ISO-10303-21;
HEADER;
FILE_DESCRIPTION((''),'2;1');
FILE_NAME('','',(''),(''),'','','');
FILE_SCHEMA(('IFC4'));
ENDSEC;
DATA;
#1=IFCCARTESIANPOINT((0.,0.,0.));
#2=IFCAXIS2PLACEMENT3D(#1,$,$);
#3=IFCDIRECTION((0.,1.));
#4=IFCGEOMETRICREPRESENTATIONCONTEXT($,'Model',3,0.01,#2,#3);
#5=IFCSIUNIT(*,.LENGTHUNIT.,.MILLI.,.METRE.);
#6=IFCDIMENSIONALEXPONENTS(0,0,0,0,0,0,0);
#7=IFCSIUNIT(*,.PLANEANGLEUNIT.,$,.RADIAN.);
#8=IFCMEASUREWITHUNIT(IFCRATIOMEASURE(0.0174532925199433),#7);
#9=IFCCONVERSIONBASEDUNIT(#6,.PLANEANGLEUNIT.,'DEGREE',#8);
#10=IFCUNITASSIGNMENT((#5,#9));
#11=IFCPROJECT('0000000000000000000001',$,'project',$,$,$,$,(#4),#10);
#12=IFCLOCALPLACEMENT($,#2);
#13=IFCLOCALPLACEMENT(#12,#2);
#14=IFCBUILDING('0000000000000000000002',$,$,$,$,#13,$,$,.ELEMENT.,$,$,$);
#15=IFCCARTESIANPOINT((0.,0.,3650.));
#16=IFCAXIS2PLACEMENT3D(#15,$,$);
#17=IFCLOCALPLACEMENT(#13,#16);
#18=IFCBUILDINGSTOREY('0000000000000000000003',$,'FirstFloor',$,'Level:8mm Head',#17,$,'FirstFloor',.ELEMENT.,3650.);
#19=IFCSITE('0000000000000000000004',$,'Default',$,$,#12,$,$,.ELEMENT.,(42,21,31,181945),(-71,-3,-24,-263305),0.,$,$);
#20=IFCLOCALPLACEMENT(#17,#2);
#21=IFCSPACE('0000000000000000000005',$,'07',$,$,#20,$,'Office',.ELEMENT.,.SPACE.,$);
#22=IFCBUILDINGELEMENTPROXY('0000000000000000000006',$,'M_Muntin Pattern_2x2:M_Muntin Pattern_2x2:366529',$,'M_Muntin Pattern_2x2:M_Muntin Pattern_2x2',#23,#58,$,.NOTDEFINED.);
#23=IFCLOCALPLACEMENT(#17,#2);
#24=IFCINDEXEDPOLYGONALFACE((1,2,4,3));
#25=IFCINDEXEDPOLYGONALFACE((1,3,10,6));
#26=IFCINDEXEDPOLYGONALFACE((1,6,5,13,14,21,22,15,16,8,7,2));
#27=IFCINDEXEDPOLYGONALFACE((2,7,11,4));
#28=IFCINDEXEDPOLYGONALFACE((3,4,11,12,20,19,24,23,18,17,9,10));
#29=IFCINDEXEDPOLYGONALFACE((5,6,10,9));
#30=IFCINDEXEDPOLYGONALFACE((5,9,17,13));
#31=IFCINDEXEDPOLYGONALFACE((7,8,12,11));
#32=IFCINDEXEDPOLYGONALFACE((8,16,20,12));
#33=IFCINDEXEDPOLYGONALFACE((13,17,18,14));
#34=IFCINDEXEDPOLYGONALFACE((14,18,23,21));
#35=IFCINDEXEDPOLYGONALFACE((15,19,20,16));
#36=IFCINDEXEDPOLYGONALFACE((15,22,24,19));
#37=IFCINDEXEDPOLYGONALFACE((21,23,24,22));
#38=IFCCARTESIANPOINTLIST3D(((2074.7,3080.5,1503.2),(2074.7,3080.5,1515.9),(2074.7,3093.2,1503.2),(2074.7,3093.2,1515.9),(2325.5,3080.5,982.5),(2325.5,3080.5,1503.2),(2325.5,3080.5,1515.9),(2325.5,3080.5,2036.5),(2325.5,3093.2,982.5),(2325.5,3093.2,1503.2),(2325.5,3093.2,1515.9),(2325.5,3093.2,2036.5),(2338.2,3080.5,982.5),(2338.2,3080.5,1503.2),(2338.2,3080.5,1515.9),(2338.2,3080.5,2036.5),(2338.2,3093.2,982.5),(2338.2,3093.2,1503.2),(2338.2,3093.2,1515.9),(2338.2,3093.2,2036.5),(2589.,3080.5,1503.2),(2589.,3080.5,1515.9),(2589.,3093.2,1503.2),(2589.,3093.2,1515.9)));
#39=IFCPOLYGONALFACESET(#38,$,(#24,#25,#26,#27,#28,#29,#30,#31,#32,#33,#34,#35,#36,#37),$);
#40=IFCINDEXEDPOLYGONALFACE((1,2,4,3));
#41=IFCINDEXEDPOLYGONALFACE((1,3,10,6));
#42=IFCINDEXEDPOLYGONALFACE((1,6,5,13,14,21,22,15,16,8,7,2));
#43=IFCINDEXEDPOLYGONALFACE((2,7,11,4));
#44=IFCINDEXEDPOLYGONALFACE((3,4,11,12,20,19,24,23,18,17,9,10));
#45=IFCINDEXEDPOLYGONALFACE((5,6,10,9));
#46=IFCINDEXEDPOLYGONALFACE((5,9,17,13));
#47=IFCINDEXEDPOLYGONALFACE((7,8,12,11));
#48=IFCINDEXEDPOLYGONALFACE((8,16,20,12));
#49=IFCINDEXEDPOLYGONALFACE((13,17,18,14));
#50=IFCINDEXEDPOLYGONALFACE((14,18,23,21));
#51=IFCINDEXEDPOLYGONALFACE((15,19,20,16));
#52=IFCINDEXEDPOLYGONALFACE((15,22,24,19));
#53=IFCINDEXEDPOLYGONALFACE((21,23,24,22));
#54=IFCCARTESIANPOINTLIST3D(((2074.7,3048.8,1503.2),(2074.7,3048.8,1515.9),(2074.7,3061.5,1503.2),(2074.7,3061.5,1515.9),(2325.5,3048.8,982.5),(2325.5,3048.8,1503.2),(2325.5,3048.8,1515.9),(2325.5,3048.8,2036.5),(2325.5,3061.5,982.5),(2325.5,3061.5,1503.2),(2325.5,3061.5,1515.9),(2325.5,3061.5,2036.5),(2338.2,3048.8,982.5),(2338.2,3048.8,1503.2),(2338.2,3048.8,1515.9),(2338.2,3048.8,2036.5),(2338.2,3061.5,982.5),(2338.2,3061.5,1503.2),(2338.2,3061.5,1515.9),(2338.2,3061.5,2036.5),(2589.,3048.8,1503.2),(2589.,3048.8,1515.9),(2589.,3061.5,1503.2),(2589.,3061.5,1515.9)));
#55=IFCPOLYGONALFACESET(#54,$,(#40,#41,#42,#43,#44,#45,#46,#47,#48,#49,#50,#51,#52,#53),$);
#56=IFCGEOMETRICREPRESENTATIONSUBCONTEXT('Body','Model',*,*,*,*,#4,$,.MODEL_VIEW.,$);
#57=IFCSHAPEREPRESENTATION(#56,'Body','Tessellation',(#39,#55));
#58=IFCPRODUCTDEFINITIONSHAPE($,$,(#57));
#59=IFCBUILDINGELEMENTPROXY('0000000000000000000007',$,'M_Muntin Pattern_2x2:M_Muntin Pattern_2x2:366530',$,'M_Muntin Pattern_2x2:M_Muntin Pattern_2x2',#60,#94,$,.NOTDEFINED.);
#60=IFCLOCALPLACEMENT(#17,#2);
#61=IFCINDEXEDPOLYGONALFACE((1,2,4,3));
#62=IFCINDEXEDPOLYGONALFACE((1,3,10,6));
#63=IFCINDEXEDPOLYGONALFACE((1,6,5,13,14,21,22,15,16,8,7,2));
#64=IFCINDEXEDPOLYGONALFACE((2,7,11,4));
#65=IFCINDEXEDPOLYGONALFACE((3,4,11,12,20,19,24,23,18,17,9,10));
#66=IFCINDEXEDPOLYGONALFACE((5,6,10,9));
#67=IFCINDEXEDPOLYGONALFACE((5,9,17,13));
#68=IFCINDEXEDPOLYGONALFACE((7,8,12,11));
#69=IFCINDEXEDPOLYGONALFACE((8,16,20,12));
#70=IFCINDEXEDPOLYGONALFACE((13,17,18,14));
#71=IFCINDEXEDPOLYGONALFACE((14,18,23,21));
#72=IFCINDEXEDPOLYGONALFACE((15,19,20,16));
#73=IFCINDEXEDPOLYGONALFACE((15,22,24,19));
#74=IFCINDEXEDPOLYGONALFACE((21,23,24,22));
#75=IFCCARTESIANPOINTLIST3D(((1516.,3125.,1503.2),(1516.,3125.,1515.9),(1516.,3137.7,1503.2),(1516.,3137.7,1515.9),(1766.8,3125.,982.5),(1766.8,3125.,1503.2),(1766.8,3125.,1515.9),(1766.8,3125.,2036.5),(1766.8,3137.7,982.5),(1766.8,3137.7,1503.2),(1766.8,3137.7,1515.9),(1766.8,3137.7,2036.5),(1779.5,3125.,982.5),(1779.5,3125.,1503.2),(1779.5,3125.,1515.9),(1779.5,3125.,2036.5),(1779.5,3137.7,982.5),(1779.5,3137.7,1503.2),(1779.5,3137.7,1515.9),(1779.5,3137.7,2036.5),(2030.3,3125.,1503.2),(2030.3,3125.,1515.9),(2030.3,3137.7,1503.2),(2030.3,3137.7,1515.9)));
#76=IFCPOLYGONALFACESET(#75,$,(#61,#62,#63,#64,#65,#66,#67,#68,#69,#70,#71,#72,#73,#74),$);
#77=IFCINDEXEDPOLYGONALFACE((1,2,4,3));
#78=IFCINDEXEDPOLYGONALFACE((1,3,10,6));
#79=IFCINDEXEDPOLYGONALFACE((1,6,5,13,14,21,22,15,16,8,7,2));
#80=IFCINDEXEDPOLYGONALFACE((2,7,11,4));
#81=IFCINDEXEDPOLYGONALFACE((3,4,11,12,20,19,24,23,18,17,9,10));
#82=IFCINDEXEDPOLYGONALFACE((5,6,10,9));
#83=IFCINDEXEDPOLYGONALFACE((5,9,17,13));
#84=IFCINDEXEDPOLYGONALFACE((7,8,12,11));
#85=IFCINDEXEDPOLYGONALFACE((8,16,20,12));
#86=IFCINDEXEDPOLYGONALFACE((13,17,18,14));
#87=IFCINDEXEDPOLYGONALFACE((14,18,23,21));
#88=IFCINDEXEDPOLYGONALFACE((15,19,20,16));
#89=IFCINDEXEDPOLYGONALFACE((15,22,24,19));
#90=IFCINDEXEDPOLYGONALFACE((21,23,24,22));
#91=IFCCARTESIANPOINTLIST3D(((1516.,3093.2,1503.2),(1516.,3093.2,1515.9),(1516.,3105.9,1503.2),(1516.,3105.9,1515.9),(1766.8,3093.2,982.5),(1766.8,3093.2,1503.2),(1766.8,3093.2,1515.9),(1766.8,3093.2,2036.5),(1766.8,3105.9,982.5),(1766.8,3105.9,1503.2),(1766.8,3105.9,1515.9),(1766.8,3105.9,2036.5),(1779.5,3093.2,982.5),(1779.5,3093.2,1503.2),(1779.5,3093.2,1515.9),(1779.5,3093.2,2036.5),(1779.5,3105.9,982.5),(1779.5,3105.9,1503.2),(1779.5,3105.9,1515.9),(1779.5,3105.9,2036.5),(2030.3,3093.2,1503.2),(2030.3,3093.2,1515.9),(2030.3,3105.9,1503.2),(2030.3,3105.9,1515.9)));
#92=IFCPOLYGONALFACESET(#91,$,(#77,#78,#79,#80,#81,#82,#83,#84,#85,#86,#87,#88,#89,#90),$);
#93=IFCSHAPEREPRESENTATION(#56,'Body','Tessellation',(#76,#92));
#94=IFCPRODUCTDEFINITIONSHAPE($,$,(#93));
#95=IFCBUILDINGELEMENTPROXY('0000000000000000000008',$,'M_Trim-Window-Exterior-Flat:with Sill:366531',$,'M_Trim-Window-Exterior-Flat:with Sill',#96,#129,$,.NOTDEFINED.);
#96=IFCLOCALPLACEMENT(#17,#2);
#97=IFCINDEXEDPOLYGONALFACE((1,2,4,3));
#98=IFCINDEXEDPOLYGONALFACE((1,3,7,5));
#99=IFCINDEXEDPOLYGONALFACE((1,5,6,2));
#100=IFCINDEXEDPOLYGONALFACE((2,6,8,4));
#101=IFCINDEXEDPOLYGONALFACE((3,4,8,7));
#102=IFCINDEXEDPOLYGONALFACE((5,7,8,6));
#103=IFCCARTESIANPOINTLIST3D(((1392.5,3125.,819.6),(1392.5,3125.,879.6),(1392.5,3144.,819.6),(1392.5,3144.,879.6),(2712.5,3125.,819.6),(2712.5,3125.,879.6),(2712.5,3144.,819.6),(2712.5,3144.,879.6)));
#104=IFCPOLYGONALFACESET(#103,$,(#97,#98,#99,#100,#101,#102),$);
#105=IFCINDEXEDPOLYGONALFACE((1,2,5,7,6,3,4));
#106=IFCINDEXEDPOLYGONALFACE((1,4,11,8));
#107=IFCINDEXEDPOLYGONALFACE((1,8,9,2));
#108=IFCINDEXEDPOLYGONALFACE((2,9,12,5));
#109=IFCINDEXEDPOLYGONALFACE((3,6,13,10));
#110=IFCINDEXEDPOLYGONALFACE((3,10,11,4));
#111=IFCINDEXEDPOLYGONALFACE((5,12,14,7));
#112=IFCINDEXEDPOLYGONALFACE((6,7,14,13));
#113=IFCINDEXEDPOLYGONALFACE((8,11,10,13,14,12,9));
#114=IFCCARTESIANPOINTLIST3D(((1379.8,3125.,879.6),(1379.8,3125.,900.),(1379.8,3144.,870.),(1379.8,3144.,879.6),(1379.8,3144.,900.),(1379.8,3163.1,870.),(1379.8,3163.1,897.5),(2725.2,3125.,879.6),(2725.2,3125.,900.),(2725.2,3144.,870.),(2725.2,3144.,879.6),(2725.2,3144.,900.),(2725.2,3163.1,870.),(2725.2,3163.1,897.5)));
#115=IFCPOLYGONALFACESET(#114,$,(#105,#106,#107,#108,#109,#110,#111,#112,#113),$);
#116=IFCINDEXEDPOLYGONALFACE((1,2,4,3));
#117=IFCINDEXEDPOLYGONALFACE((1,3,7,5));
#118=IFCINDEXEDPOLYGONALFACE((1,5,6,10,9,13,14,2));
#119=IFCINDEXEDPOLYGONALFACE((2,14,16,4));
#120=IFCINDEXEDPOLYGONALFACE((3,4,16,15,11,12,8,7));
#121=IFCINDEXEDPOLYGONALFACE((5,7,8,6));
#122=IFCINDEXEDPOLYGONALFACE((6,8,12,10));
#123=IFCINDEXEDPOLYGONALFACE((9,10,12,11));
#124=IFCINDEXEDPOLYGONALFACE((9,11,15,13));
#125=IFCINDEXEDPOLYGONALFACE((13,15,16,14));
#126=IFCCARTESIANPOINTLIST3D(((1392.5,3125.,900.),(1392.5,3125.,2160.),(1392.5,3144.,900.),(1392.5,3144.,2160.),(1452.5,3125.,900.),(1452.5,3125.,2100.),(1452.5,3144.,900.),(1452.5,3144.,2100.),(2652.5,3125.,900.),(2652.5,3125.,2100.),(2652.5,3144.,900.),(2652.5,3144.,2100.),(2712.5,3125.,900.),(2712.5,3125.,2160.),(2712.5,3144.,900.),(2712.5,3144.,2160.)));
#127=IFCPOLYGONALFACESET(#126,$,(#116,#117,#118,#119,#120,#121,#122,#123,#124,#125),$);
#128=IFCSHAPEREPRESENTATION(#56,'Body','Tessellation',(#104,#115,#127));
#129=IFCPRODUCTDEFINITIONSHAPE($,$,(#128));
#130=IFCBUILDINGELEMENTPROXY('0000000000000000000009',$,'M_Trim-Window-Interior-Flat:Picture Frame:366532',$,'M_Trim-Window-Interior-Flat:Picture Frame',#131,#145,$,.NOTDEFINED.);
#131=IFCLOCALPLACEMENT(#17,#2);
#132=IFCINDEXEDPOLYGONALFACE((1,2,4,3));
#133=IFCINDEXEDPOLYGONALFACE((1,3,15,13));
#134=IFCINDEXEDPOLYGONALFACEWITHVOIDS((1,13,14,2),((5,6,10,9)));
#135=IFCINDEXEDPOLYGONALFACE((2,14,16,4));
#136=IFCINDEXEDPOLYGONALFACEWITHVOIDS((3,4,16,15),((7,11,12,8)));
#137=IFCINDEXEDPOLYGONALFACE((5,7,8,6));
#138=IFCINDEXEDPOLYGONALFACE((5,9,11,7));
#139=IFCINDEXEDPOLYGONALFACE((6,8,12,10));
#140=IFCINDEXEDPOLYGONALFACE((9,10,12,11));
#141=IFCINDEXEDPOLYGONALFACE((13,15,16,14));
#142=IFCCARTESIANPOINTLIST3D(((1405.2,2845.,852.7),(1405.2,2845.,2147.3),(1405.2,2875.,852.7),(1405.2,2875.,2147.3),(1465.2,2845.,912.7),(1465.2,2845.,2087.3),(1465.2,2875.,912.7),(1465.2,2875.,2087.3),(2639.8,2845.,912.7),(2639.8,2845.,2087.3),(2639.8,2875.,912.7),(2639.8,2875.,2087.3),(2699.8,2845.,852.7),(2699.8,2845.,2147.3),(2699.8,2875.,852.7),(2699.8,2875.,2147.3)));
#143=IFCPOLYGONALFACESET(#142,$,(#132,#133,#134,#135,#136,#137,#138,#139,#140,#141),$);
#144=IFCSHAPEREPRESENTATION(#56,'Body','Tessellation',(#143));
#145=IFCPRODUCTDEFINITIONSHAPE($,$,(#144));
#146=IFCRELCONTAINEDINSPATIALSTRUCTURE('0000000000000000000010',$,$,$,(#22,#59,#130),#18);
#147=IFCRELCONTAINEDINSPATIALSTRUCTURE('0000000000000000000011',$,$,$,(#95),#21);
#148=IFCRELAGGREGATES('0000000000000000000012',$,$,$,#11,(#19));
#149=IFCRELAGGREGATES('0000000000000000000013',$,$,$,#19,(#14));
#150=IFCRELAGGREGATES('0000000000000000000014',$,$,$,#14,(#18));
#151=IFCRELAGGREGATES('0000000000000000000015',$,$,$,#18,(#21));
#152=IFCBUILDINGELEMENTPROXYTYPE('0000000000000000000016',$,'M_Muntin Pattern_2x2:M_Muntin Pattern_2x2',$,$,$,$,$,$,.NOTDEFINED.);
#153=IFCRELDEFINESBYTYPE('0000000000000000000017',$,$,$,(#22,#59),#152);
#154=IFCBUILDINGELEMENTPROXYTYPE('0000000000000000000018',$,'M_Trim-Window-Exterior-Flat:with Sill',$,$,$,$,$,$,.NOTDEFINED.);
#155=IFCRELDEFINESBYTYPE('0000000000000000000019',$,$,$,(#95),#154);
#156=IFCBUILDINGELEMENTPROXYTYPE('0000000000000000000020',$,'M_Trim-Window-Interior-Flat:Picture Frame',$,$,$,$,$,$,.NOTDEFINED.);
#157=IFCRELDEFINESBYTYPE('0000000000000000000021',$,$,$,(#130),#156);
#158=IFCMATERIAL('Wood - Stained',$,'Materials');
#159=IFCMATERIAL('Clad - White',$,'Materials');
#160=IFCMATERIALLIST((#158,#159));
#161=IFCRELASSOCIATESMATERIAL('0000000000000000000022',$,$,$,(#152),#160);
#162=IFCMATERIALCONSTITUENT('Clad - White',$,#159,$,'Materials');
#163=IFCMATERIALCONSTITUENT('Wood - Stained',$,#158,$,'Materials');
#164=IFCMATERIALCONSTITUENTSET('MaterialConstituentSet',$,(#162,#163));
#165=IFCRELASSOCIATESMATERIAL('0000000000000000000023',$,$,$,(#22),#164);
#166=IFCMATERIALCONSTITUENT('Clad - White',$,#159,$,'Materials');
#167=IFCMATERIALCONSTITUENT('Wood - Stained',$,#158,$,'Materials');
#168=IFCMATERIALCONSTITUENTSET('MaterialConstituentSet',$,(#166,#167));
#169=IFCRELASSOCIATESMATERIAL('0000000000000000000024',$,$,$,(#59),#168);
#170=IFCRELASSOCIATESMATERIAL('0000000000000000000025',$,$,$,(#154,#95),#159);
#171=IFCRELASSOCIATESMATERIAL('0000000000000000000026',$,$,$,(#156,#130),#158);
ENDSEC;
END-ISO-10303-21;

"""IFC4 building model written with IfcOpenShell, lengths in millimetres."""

from ifc_helpers import new_model, entity, si_unit, converted_unit, direction, frame, frame_2d, origin, place, context, subcontext, project, spatial, polyline, rectangle, outline, extrude, source, transform, mapped, material, material_list, constituent, constituent_set, type_object, type_shapes, element, save


model = new_model("IFC4")

# Units and contexts
model_context = context("Model", 3, precision=0.01, world=origin(), true_north=direction((0.0, 1.0)))
body_context = subcontext(model_context, "Body", "Model", "MODEL_VIEW")
ifc_project = project(units=[si_unit("LENGTHUNIT", "METRE", prefix="MILLI"), converted_unit("PLANEANGLEUNIT", "DEGREE", entity("IfcRatioMeasure", 0.0174532925199433), si_unit("PLANEANGLEUNIT", "RADIAN"), dimensions=[0, 0, 0, 0, 0, 0, 0])], contexts=[model_context])

# Site, building, storey
site_placement = place(None, origin())
site = spatial("IfcSite", under=ifc_project, at=site_placement, Name="Default", CompositionType="ELEMENT", RefLatitude=(42, 21, 31, 181945), RefLongitude=(-71, -3, -24, -263305), RefElevation=0.0)
building_placement = place(site_placement, origin())
building = spatial("IfcBuilding", under=site, at=building_placement, CompositionType="ELEMENT")
storey_placement = place(building_placement, frame((0.0, 0.0, 3650.0)))
storey = spatial("IfcBuildingStorey", under=building, at=storey_placement, Name="FirstFloor", ObjectType="Level:8mm Head", LongName="FirstFloor", CompositionType="ELEMENT", Elevation=3650.0)

# Building element proxies
ifc_material_1 = material(Name="Clad - White", Category="Materials")
ifc_constituent_1 = constituent(ifc_material_1, Name="Clad - White", Category="Materials")
ifc_material_2 = material(Name="Wood - Stained", Category="Materials")
ifc_constituent_2 = constituent(ifc_material_2, Name="Wood - Stained", Category="Materials")
ifc_constituent_set_1 = constituent_set(constituents=[ifc_constituent_1, ifc_constituent_2], Name="MaterialConstituentSet")
ifc_material_list_1 = material_list([ifc_material_2, ifc_material_1])
building_element_proxy_type_1 = type_object("IfcBuildingElementProxyType", Name="M_Muntin Pattern_2x2:M_Muntin Pattern_2x2", PredefinedType="NOTDEFINED", material=ifc_material_list_1)
shared_shape_1 = source(origin(), body_context, "Body", "SweptSolid", [
    extrude(outline(polyline([(6.4, -6.4), (527.0, -6.4), (527.0, 6.3), (6.4, 6.3), (6.4, 257.1), (-6.3, 257.1), (-6.3, 6.3), (-527.0, 6.3), (-527.0, -6.4), (-6.3, -6.4), (-6.3, -257.1), (6.4, -257.1), (6.4, -6.4)])), frame((0.0, 9.5, 527.0), z_axis=(0.0, 1.0, 0.0), x_axis=(0.0, 0.0, 1.0)), (0.0, 0.0, 1.0), 12.7),
    extrude(outline(polyline([(6.4, -6.4), (527.0, -6.4), (527.0, 6.3), (6.4, 6.3), (6.4, 257.1), (-6.3, 257.1), (-6.3, 6.3), (-527.0, 6.3), (-527.0, -6.4), (-6.3, -6.4), (-6.3, -257.1), (6.4, -257.1), (6.4, -6.4)])), frame((0.0, -22.2, 527.0), z_axis=(0.0, 1.0, 0.0), x_axis=(0.0, 0.0, 1.0)), (0.0, 0.0, 1.0), 12.7),
])
type_shapes(building_element_proxy_type_1, [shared_shape_1])
proxy_1_placement = place(storey_placement, frame((2331.9, 3071.0, 982.5)))
element("IfcBuildingElementProxy", 1, at=proxy_1_placement, inside=storey, type_object=building_element_proxy_type_1, material=ifc_constituent_set_1, Name="M_Muntin Pattern_2x2:M_Muntin Pattern_2x2:366529", ObjectType="M_Muntin Pattern_2x2:M_Muntin Pattern_2x2", PredefinedType="NOTDEFINED", context=body_context, shape_type="MappedRepresentation", body=[
    mapped(shared_shape_1, transform((0.0, 0.0, 0.0), scale=1.0)),
])
ifc_constituent_3 = constituent(ifc_material_1, Name="Clad - White", Category="Materials")
ifc_constituent_4 = constituent(ifc_material_2, Name="Wood - Stained", Category="Materials")
ifc_constituent_set_2 = constituent_set(constituents=[ifc_constituent_3, ifc_constituent_4], Name="MaterialConstituentSet")
proxy_2_placement = place(storey_placement, frame((1773.1, 3115.5, 982.5)))
element("IfcBuildingElementProxy", 2, at=proxy_2_placement, inside=storey, type_object=building_element_proxy_type_1, material=ifc_constituent_set_2, Name="M_Muntin Pattern_2x2:M_Muntin Pattern_2x2:366530", ObjectType="M_Muntin Pattern_2x2:M_Muntin Pattern_2x2", PredefinedType="NOTDEFINED", context=body_context, shape_type="MappedRepresentation", body=[
    mapped(shared_shape_1, transform((0.0, 0.0, 0.0), scale=1.0)),
])

# Shared definitions
space_1_placement = place(storey_placement, origin())
space_1 = spatial("IfcSpace", under=storey, at=space_1_placement, Name="07", LongName="Office", CompositionType="ELEMENT", PredefinedType="SPACE")

# Building element proxies
building_element_proxy_type_2 = type_object("IfcBuildingElementProxyType", Name="M_Trim-Window-Exterior-Flat:with Sill", PredefinedType="NOTDEFINED", material=ifc_material_1)
shared_shape_2 = source(origin(), body_context, "Body", "SweptSolid", [
    extrude(rectangle(XDim=1320.0, YDim=60.0, at=frame_2d((0.0, 0.0), x_axis=(1.0, 0.0))), frame((0.0, -1250.4, 0.0), z_axis=(0.0, 0.0, 1.0), x_axis=(-1.0, 0.0, 0.0)), (0.0, 0.0, 1.0), 19.1),
    extrude(outline(polyline([(-19.0, -15.2), (0.0, -15.2), (0.0, -5.7), (19.0, -5.7), (19.0, 14.8), (0.0, 14.8), (-19.0, 12.3), (-19.0, -15.2)])), frame((-672.7, -1214.8, 19.0), z_axis=(1.0, 0.0, 0.0), x_axis=(0.0, 0.0, -1.0)), (0.0, 0.0, 1.0), 1345.4),
    extrude(outline(polyline([(-645.0, -660.0), (615.0, -660.0), (615.0, -600.0), (-585.0, -600.0), (-585.0, 600.0), (615.0, 600.0), (615.0, 660.0), (-645.0, 660.0), (-645.0, -660.0)])), frame((0.0, -585.0, 0.0), z_axis=(0.0, 0.0, 1.0), x_axis=(0.0, -1.0, 0.0)), (0.0, 0.0, 1.0), 19.1),
])
type_shapes(building_element_proxy_type_2, [shared_shape_2])
proxy_3_placement = place(space_1_placement, frame((2052.5, 3125.0, 2100.0), z_axis=(0.0, 1.0, 0.0), x_axis=(-1.0, 0.0, 0.0)))
element("IfcBuildingElementProxy", 3, at=proxy_3_placement, inside=space_1, type_object=building_element_proxy_type_2, material=ifc_material_1, Name="M_Trim-Window-Exterior-Flat:with Sill:366531", ObjectType="M_Trim-Window-Exterior-Flat:with Sill", PredefinedType="NOTDEFINED", context=body_context, shape_type="MappedRepresentation", body=[
    mapped(shared_shape_2, transform((0.0, 0.0, 0.0), scale=1.0)),
])
building_element_proxy_type_3 = type_object("IfcBuildingElementProxyType", Name="M_Trim-Window-Interior-Flat:Picture Frame", PredefinedType="NOTDEFINED", material=ifc_material_2)
shared_shape_3 = source(origin(), body_context, "Body", "SweptSolid", [
    extrude(outline(polyline([(-647.3, -647.3), (647.3, -647.3), (647.3, 647.3), (-647.3, 647.3), (-647.3, -647.3)]), holes=[polyline([(-587.3, -587.3), (-587.3, 587.3), (587.3, 587.3), (587.3, -587.3), (-587.3, -587.3)])]), frame((0.0, -600.0, 0.0), z_axis=(0.0, 0.0, 1.0), x_axis=(-1.0, 0.0, 0.0)), (0.0, 0.0, 1.0), 30.0),
])
type_shapes(building_element_proxy_type_3, [shared_shape_3])
proxy_4_placement = place(storey_placement, frame((2052.5, 2875.0, 2100.0), z_axis=(0.0, -1.0, 0.0), x_axis=(1.0, 0.0, 0.0)))
element("IfcBuildingElementProxy", 4, at=proxy_4_placement, inside=storey, type_object=building_element_proxy_type_3, material=ifc_material_2, Name="M_Trim-Window-Interior-Flat:Picture Frame:366532", ObjectType="M_Trim-Window-Interior-Flat:Picture Frame", PredefinedType="NOTDEFINED", context=body_context, shape_type="MappedRepresentation", body=[
    mapped(shared_shape_3, transform((0.0, 0.0, 0.0), scale=1.0)),
])

save(model, "model.ifc")
